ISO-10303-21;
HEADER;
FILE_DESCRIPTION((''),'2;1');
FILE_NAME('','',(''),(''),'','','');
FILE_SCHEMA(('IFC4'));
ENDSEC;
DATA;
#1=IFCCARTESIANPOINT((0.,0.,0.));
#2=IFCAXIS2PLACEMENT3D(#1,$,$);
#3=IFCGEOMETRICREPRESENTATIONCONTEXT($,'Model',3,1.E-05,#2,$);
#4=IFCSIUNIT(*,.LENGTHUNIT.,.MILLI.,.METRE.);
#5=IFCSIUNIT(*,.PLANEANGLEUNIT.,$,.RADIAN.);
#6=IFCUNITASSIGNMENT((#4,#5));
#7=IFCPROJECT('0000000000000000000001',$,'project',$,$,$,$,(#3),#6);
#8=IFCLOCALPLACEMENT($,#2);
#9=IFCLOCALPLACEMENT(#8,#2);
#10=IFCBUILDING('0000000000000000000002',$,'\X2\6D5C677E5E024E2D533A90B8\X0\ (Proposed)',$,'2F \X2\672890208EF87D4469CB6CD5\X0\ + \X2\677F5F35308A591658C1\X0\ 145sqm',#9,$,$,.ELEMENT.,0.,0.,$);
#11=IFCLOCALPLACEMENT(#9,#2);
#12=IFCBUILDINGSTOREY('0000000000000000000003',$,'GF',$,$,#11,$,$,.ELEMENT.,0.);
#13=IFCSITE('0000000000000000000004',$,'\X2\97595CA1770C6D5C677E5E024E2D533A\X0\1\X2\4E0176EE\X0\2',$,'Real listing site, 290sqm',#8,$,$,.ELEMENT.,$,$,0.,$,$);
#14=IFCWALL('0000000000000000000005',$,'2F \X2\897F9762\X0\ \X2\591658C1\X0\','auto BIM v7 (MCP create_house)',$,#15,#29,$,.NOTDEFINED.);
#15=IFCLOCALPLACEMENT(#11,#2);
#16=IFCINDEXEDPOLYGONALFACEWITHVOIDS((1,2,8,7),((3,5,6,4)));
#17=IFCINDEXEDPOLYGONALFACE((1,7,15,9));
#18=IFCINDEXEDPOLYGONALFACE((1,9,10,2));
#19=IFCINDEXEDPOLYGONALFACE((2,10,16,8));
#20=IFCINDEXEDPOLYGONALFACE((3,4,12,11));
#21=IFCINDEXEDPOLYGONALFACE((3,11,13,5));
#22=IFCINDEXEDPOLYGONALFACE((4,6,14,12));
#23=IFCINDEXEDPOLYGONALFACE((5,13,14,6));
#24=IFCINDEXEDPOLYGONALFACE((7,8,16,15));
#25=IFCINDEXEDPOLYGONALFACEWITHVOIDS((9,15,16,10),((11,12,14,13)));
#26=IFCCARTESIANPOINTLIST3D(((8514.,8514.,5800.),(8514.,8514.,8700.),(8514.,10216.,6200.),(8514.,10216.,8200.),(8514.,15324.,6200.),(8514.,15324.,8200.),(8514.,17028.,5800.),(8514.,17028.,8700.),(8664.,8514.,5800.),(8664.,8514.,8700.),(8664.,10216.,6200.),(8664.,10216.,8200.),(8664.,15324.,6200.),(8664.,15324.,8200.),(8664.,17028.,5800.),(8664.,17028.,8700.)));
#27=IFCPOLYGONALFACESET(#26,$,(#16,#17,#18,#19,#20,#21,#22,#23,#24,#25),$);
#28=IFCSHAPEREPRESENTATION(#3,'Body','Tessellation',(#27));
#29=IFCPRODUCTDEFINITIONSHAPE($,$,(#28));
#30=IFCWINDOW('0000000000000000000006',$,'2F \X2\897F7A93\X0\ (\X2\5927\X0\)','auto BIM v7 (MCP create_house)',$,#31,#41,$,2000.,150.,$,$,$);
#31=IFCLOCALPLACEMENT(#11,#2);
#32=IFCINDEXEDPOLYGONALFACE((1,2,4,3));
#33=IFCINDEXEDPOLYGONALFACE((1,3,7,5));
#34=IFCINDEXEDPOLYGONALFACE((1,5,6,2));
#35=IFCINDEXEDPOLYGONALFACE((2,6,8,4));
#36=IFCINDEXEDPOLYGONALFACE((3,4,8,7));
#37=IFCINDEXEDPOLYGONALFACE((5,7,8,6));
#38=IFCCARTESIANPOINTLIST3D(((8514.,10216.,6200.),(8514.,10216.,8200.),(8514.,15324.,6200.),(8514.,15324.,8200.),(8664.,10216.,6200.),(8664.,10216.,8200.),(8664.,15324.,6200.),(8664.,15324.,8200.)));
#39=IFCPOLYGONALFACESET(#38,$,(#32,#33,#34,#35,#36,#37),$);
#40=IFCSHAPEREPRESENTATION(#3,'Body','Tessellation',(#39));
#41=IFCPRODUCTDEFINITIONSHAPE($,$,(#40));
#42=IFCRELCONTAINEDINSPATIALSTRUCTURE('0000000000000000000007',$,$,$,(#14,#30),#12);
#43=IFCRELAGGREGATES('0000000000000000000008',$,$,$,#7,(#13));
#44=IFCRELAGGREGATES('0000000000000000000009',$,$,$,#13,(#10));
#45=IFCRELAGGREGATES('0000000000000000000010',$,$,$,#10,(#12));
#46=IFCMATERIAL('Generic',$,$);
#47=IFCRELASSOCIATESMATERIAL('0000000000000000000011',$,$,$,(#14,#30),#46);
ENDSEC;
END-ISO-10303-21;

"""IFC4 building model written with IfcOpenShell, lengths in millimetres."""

from ifc_helpers import new_model, si_unit, frame, frame_2d, origin, place, context, project, spatial, rectangle, extrude, material, element, fill, save


model = new_model("IFC4")

# Units and contexts
model_context = context("Model", 3, precision=1e-05, world=origin())
ifc_project = project(units=[si_unit("LENGTHUNIT", "METRE", prefix="MILLI"), si_unit("PLANEANGLEUNIT", "RADIAN")], contexts=[model_context])

# Site, building, storey
site_placement = place(None, origin())
site = spatial("IfcSite", under=ifc_project, at=site_placement, Name="静岡県浜松市中区1丁目2", ObjectType="Real listing site, 290sqm", CompositionType="ELEMENT", RefElevation=0.0)
building_placement = place(site_placement, origin())
building = spatial("IfcBuilding", under=site, at=building_placement, Name="浜松市中区邸 (Proposed)", ObjectType="2F 木造軸組構法 + 板張り外壁 145sqm", CompositionType="ELEMENT", ElevationOfRefHeight=0.0, ElevationOfTerrain=0.0)
storey_placement = place(building_placement, origin())
storey = spatial("IfcBuildingStorey", under=building, at=storey_placement, Name="GF", CompositionType="ELEMENT", Elevation=0.0)

# Shared definitions
ifc_material = material(Name="Generic")

# Wall, opening, window
wall_1_placement = place(storey_placement, frame((4257.0, 4257.0, 2900.0)))
wall_1 = element("IfcWall", 1, at=wall_1_placement, inside=storey, material=ifc_material, Name="2F 西面 外壁", Description="auto BIM v7 (MCP create_house)", PredefinedType="NOTDEFINED", context=model_context, shape_type="SweptSolid", body=[
    extrude(rectangle(XDim=150.0, YDim=8514.0, at=frame_2d((75.0, 4257.0))), frame((4257.0, 4257.0, 2900.0)), (0.0, 0.0, 1.0), 2900.0),
])
opening_1_placement = place(storey_placement, frame((4257.0, 5108.0, 3100.0)))
opening_1 = element("IfcOpeningElement", 2, at=opening_1_placement, cuts=wall_1, PredefinedType="NOTDEFINED", context=model_context, shape_type="SweptSolid", body=[
    extrude(rectangle(XDim=150.0, YDim=5108.0, at=frame_2d((75.0, 2554.0))), frame((4257.0, 5108.0, 3100.0)), (0.0, 0.0, 1.0), 2000.0),
])
window_1_placement = place(storey_placement, frame((4257.0, 5108.0, 3100.0)))
window_1 = element("IfcWindow", 3, at=window_1_placement, inside=storey, material=ifc_material, Name="2F 西窓 (大)", Description="auto BIM v7 (MCP create_house)", OverallHeight=2000.0, OverallWidth=150.0, context=model_context, shape_type="SweptSolid", body=[
    extrude(rectangle(XDim=150.0, YDim=5108.0, at=frame_2d((75.0, 2554.0))), frame((4257.0, 5108.0, 3100.0)), (0.0, 0.0, 1.0), 2000.0),
])
fill(opening_1, window_1)

save(model, "model.ifc")
